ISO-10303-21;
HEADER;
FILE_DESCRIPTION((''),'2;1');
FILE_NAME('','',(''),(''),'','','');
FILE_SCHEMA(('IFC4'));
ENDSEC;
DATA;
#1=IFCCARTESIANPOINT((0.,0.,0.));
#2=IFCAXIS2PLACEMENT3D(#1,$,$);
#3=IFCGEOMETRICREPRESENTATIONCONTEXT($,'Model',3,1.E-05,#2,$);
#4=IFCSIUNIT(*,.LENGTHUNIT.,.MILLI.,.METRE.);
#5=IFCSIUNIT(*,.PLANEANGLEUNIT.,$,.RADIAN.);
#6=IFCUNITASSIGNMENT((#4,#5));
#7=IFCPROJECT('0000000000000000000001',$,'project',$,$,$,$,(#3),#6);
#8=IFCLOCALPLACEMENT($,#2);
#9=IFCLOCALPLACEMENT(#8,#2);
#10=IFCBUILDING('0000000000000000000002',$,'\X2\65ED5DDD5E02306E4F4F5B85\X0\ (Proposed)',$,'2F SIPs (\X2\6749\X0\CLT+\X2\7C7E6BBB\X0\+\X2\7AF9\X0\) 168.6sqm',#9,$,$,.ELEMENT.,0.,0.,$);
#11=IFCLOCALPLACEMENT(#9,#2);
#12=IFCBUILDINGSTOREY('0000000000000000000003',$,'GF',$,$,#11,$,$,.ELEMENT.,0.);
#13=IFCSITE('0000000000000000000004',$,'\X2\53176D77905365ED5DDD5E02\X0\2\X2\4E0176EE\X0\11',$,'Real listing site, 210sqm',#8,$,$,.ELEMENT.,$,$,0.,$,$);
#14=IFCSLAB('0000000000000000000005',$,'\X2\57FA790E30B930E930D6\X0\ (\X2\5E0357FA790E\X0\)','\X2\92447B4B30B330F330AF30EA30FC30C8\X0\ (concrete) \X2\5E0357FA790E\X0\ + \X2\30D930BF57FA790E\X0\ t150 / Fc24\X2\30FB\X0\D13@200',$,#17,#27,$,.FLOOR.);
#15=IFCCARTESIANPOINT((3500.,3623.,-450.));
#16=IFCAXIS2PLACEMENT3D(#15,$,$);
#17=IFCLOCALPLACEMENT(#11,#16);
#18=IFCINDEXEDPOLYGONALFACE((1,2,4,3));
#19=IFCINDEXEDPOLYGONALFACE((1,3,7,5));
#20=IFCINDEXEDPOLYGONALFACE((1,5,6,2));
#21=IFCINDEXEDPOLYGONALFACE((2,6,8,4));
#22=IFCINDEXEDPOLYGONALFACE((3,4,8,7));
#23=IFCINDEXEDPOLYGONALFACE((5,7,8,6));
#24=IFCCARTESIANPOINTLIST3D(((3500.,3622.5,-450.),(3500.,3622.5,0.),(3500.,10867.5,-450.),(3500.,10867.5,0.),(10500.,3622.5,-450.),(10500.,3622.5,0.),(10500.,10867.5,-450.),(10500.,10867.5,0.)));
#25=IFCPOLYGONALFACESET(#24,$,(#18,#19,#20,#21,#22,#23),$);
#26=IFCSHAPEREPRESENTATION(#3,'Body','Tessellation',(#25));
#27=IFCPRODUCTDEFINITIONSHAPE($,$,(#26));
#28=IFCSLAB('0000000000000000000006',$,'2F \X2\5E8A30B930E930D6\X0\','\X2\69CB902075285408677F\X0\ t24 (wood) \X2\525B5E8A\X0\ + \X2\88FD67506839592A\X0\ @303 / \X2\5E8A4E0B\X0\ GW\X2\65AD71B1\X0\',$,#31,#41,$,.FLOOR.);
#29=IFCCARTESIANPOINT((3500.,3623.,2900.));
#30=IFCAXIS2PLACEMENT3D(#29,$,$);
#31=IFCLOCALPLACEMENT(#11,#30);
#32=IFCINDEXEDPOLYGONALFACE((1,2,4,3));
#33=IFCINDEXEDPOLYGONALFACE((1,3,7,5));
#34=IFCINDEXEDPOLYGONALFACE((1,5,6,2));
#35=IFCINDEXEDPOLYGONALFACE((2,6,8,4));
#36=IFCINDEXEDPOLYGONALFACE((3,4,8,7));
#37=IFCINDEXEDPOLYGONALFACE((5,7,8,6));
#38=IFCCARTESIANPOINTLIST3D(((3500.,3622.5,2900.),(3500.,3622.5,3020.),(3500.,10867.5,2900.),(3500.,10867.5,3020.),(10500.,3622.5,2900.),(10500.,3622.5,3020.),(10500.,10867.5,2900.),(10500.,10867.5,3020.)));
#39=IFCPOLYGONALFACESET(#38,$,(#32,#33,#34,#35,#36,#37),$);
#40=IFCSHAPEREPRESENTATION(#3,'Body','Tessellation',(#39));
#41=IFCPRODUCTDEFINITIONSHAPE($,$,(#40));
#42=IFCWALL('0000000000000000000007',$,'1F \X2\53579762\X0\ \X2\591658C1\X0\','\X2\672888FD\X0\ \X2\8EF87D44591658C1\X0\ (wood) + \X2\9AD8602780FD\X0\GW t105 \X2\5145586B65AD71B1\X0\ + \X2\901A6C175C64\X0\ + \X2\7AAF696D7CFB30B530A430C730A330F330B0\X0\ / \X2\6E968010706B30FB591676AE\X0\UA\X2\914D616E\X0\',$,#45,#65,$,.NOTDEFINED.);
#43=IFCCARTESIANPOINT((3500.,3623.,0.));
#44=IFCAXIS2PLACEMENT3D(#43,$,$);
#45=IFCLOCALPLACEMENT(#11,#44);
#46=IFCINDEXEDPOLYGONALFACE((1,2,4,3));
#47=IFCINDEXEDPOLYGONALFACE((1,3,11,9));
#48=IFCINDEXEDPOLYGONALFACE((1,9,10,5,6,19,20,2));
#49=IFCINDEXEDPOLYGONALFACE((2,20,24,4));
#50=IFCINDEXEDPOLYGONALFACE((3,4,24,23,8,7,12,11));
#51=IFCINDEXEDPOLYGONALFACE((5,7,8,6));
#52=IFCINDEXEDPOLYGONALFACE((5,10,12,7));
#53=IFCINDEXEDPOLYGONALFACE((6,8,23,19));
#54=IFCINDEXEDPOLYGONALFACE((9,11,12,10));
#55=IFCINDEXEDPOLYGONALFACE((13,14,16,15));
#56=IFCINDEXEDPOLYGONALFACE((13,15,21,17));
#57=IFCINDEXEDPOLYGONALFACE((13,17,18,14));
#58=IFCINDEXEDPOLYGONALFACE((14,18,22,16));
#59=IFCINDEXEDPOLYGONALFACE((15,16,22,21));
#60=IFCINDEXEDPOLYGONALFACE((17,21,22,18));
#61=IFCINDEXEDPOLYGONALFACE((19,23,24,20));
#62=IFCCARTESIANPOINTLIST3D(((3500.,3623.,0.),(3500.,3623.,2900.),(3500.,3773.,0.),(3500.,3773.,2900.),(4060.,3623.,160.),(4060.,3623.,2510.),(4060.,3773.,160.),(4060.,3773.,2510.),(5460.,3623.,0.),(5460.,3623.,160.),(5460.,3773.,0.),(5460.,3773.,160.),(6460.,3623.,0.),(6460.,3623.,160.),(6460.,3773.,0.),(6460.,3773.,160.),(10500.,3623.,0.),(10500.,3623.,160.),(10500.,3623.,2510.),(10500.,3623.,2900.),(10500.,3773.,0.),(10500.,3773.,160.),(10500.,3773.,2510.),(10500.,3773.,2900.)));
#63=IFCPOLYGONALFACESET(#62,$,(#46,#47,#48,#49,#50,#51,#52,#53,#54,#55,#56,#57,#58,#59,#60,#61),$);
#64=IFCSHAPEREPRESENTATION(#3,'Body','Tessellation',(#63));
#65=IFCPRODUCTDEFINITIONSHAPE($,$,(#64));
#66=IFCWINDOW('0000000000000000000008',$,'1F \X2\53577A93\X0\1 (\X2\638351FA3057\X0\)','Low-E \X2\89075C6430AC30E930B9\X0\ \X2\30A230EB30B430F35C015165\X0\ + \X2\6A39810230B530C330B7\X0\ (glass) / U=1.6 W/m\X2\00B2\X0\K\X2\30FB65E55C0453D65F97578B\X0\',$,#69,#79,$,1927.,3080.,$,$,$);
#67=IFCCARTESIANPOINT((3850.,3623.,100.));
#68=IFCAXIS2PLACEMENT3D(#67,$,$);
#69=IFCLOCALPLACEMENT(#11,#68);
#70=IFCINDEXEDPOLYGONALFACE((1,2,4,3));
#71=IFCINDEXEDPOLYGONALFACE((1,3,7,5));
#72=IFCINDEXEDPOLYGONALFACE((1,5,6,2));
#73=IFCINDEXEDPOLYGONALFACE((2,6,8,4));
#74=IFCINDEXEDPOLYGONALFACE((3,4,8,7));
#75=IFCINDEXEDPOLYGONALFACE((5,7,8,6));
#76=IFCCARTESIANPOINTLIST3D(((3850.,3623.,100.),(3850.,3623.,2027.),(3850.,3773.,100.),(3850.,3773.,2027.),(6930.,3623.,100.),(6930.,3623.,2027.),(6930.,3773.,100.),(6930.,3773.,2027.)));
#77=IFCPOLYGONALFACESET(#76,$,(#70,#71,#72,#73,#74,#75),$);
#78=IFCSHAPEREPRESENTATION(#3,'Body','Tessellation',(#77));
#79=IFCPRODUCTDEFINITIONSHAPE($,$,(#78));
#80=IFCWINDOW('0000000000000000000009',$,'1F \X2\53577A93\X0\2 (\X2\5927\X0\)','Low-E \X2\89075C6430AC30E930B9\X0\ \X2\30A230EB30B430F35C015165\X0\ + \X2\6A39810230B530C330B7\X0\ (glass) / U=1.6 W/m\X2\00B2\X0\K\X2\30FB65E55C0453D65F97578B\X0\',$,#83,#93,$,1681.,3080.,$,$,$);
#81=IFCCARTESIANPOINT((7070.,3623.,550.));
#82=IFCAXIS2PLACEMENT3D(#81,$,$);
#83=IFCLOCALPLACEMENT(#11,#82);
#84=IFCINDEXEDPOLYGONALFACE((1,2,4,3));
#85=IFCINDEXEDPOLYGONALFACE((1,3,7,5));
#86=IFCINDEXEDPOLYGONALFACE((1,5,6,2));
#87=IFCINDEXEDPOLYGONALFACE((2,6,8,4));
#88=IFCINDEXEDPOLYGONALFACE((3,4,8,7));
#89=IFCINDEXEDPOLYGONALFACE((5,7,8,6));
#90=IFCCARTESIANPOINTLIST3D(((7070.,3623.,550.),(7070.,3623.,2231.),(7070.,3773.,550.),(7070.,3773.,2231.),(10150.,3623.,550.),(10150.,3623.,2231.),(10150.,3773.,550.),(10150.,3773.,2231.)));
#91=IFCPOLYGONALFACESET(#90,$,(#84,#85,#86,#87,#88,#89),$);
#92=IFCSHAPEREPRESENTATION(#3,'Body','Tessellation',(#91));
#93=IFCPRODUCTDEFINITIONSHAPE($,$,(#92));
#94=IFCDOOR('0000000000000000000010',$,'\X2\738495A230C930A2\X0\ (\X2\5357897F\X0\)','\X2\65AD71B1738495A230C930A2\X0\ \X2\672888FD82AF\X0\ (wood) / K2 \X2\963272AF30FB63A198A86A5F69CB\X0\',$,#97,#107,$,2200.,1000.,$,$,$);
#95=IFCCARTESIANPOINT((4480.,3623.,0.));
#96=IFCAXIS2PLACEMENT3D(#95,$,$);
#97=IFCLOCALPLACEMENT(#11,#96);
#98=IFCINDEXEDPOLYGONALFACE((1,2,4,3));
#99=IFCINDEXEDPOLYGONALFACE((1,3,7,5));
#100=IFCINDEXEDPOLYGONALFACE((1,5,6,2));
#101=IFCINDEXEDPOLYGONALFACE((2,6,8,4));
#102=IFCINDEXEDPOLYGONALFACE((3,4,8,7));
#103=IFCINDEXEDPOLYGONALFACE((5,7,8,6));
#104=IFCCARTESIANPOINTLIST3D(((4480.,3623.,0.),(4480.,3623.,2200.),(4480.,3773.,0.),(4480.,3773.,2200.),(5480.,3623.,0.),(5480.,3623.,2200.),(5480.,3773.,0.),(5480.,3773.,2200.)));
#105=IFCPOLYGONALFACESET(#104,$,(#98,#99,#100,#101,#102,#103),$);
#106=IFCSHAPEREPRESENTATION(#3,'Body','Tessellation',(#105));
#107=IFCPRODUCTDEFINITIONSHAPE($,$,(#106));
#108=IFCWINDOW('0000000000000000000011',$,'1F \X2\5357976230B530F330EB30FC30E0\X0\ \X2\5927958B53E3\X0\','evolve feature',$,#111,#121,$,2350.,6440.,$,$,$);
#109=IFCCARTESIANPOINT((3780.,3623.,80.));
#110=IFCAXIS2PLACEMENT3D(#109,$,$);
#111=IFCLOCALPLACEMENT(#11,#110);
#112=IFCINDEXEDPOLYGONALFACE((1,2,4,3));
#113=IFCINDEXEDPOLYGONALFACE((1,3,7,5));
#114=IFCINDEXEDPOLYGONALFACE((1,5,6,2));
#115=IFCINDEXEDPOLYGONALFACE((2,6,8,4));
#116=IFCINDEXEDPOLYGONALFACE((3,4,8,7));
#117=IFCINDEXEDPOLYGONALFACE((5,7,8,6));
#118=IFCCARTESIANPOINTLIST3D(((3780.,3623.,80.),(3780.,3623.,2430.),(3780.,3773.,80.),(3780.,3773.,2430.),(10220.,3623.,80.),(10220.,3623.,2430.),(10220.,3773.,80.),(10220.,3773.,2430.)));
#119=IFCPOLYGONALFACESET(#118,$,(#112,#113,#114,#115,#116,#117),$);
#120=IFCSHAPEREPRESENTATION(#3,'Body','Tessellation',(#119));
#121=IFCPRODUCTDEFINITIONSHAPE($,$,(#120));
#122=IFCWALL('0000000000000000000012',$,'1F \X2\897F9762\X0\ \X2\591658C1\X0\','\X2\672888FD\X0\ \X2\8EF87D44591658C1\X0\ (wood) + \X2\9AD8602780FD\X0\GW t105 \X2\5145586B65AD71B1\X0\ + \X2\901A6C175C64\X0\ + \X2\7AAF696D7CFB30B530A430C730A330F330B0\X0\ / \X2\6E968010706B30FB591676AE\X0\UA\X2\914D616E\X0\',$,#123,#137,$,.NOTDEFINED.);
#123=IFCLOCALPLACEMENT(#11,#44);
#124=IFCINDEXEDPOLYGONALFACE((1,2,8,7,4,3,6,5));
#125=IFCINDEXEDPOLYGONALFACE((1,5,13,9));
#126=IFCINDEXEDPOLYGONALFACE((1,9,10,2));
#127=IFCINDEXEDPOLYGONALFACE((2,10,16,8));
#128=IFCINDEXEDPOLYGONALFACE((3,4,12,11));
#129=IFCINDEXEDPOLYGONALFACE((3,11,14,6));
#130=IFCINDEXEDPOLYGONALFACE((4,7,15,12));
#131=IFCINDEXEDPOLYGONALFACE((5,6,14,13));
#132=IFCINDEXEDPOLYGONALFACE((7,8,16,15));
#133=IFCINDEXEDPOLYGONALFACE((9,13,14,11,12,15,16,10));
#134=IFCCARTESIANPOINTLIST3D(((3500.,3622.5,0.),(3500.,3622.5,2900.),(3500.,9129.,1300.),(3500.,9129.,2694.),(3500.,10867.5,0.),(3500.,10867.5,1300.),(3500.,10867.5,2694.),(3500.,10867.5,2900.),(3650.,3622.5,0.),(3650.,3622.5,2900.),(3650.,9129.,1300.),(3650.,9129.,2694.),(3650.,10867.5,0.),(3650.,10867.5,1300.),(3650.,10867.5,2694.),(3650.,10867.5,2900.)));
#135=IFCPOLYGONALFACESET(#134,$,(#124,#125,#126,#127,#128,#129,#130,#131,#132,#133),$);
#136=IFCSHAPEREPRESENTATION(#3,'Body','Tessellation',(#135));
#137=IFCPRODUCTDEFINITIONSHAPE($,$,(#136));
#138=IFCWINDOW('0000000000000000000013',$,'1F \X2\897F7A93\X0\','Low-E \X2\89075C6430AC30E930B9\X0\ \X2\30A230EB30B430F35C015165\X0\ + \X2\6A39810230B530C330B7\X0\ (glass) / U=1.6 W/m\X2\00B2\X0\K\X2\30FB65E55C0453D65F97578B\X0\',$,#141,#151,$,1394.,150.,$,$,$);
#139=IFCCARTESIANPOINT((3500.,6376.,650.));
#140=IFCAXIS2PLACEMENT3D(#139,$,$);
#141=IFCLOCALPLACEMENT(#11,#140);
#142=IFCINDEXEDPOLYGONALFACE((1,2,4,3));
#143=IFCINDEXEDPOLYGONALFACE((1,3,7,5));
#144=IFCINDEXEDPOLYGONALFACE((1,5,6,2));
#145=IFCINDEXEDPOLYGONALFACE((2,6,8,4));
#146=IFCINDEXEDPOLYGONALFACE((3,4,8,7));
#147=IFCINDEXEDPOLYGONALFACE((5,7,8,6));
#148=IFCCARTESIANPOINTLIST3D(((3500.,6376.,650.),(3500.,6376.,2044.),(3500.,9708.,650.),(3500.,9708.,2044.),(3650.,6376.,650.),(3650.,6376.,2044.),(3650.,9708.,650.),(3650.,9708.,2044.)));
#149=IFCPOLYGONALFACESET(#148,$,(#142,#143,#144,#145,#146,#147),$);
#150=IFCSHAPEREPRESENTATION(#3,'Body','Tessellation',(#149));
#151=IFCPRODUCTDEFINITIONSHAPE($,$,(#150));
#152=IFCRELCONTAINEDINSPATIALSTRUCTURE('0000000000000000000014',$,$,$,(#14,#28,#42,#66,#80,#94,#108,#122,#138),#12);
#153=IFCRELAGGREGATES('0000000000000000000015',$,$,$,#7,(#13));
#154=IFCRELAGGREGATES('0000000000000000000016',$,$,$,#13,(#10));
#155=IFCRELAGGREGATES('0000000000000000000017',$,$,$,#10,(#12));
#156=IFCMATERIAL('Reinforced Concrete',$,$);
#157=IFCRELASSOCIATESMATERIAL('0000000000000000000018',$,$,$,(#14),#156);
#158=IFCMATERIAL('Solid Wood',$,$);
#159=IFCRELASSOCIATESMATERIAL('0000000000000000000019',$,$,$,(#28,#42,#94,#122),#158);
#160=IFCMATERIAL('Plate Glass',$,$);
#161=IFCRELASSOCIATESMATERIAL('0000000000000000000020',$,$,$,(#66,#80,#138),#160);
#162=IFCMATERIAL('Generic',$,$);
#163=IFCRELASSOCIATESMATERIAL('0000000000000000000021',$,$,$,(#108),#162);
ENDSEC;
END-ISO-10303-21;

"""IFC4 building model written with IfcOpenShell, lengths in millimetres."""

from ifc_helpers import new_model, si_unit, frame, frame_2d, origin, place, context, project, spatial, rectangle, extrude, material, element, fill, save


model = new_model("IFC4")

# Units and contexts
model_context = context("Model", 3, precision=1e-05, world=origin())
ifc_project = project(units=[si_unit("LENGTHUNIT", "METRE", prefix="MILLI"), si_unit("PLANEANGLEUNIT", "RADIAN")], contexts=[model_context])

# Site, building, storey
site_placement = place(None, origin())
site = spatial("IfcSite", under=ifc_project, at=site_placement, Name="北海道旭川市2丁目11", ObjectType="Real listing site, 210sqm", CompositionType="ELEMENT", RefElevation=0.0)
building_placement = place(site_placement, origin())
building = spatial("IfcBuilding", under=site, at=building_placement, Name="旭川市の住宅 (Proposed)", ObjectType="2F SIPs (杉CLT+籾殻+竹) 168.6sqm", CompositionType="ELEMENT", ElevationOfRefHeight=0.0, ElevationOfTerrain=0.0)
storey_placement = place(building_placement, origin())
storey = spatial("IfcBuildingStorey", under=building, at=storey_placement, Name="GF", CompositionType="ELEMENT", Elevation=0.0)

# Slabs
ifc_material_1 = material(Name="Reinforced Concrete")
slab_1_placement = place(storey_placement, frame((3500.0, 3623.0, -450.0)))
element("IfcSlab", 1, at=slab_1_placement, inside=storey, material=ifc_material_1, Name="基礎スラブ (布基礎)", Description="鉄筋コンクリート (concrete) 布基礎 + ベタ基礎 t150 / Fc24・D13@200", PredefinedType="FLOOR", context=model_context, shape_type="SweptSolid", body=[
    extrude(rectangle(XDim=7000.0, YDim=7245.0, at=frame_2d((3500.0, 3622.0))), frame((3500.0, 3623.0, -450.0)), (0.0, 0.0, 1.0), 450.0),
])
ifc_material_2 = material(Name="Solid Wood")
slab_2_placement = place(storey_placement, frame((3500.0, 3623.0, 2900.0)))
element("IfcSlab", 2, at=slab_2_placement, inside=storey, material=ifc_material_2, Name="2F 床スラブ", Description="構造用合板 t24 (wood) 剛床 + 製材根太 @303 / 床下 GW断熱", PredefinedType="FLOOR", context=model_context, shape_type="SweptSolid", body=[
    extrude(rectangle(XDim=7000.0, YDim=7245.0, at=frame_2d((3500.0, 3622.0))), frame((3500.0, 3623.0, 2900.0)), (0.0, 0.0, 1.0), 120.0),
])
ifc_material_3 = material(Name="Generic")

# Wall, openings, windows, door
wall_1_placement = place(storey_placement, frame((3500.0, 3623.0, 0.0)))
wall_1 = element("IfcWall", 3, at=wall_1_placement, inside=storey, material=ifc_material_2, Name="1F 南面 外壁", Description="木製 軸組外壁 (wood) + 高性能GW t105 充填断熱 + 通気層 + 窯業系サイディング / 準耐火・外皮UA配慮", PredefinedType="NOTDEFINED", context=model_context, shape_type="SweptSolid", body=[
    extrude(rectangle(XDim=7000.0, YDim=150.0, at=frame_2d((3500.0, 75.0))), frame((3500.0, 3623.0, 0.0)), (0.0, 0.0, 1.0), 2900.0),
])
opening_1_placement = place(storey_placement, frame((3850.0, 3623.0, 100.0)))
opening_1 = element("IfcOpeningElement", 4, at=opening_1_placement, cuts=wall_1, PredefinedType="NOTDEFINED", context=model_context, shape_type="SweptSolid", body=[
    extrude(rectangle(XDim=3080.0, YDim=150.0, at=frame_2d((1540.0, 75.0))), frame((3850.0, 3623.0, 100.0)), (0.0, 0.0, 1.0), 1927.0),
])
opening_2_placement = place(storey_placement, frame((7070.0, 3623.0, 550.0)))
opening_2 = element("IfcOpeningElement", 5, at=opening_2_placement, cuts=wall_1, PredefinedType="NOTDEFINED", context=model_context, shape_type="SweptSolid", body=[
    extrude(rectangle(XDim=3080.0, YDim=150.0, at=frame_2d((1540.0, 75.0))), frame((7070.0, 3623.0, 550.0)), (0.0, 0.0, 1.0), 1681.0),
])
opening_3_placement = place(storey_placement, frame((4480.0, 3623.0, 0.0)))
opening_3 = element("IfcOpeningElement", 6, at=opening_3_placement, cuts=wall_1, PredefinedType="NOTDEFINED", context=model_context, shape_type="SweptSolid", body=[
    extrude(rectangle(XDim=1000.0, YDim=150.0, at=frame_2d((500.0, 75.0))), frame((4480.0, 3623.0, 0.0)), (0.0, 0.0, 1.0), 2200.0),
])
opening_4_placement = place(storey_placement, frame((3780.0, 3623.0, 80.0)))
opening_4 = element("IfcOpeningElement", 7, at=opening_4_placement, cuts=wall_1, PredefinedType="NOTDEFINED", context=model_context, shape_type="SweptSolid", body=[
    extrude(rectangle(XDim=6440.0, YDim=150.0, at=frame_2d((3220.0, 75.0))), frame((3780.0, 3623.0, 80.0)), (0.0, 0.0, 1.0), 2350.0),
])
ifc_material_4 = material(Name="Plate Glass")
window_1_placement = place(storey_placement, frame((3850.0, 3623.0, 100.0)))
window_1 = element("IfcWindow", 8, at=window_1_placement, inside=storey, material=ifc_material_4, Name="1F 南窓1 (掃出し)", Description="Low-E 複層ガラス アルゴン封入 + 樹脂サッシ (glass) / U=1.6 W/m²K・日射取得型", OverallHeight=1927.0, OverallWidth=3080.0, context=model_context, shape_type="SweptSolid", body=[
    extrude(rectangle(XDim=3080.0, YDim=150.0, at=frame_2d((1540.0, 75.0))), frame((3850.0, 3623.0, 100.0)), (0.0, 0.0, 1.0), 1927.0),
])
fill(opening_1, window_1)
window_2_placement = place(storey_placement, frame((7070.0, 3623.0, 550.0)))
window_2 = element("IfcWindow", 9, at=window_2_placement, inside=storey, material=ifc_material_4, Name="1F 南窓2 (大)", Description="Low-E 複層ガラス アルゴン封入 + 樹脂サッシ (glass) / U=1.6 W/m²K・日射取得型", OverallHeight=1681.0, OverallWidth=3080.0, context=model_context, shape_type="SweptSolid", body=[
    extrude(rectangle(XDim=3080.0, YDim=150.0, at=frame_2d((1540.0, 75.0))), frame((7070.0, 3623.0, 550.0)), (0.0, 0.0, 1.0), 1681.0),
])
fill(opening_2, window_2)
door_placement = place(storey_placement, frame((4480.0, 3623.0, 0.0)))
door = element("IfcDoor", 10, at=door_placement, inside=storey, material=ifc_material_2, Name="玄関ドア (南西)", Description="断熱玄関ドア 木製芯 (wood) / K2 防犯・採風機構", OverallHeight=2200.0, OverallWidth=1000.0, context=model_context, shape_type="SweptSolid", body=[
    extrude(rectangle(XDim=1000.0, YDim=150.0, at=frame_2d((500.0, 75.0))), frame((4480.0, 3623.0, 0.0)), (0.0, 0.0, 1.0), 2200.0),
])
fill(opening_3, door)
window_3_placement = place(storey_placement, frame((3780.0, 3623.0, 80.0)))
window_3 = element("IfcWindow", 11, at=window_3_placement, inside=storey, material=ifc_material_3, Name="1F 南面サンルーム 大開口", Description="evolve feature", OverallHeight=2350.0, OverallWidth=6440.0, context=model_context, shape_type="SweptSolid", body=[
    extrude(rectangle(XDim=6440.0, YDim=150.0, at=frame_2d((3220.0, 75.0))), frame((3780.0, 3623.0, 80.0)), (0.0, 0.0, 1.0), 2350.0),
])
fill(opening_4, window_3)

# Wall, opening, window
wall_2_placement = place(storey_placement, frame((3500.0, 3623.0, 0.0)))
wall_2 = element("IfcWall", 12, at=wall_2_placement, inside=storey, material=ifc_material_2, Name="1F 西面 外壁", Description="木製 軸組外壁 (wood) + 高性能GW t105 充填断熱 + 通気層 + 窯業系サイディング / 準耐火・外皮UA配慮", PredefinedType="NOTDEFINED", context=model_context, shape_type="SweptSolid", body=[
    extrude(rectangle(XDim=150.0, YDim=7245.0, at=frame_2d((75.0, 3622.0))), frame((3500.0, 3623.0, 0.0)), (0.0, 0.0, 1.0), 2900.0),
])
opening_5_placement = place(storey_placement, frame((3500.0, 6376.0, 650.0)))
opening_5 = element("IfcOpeningElement", 13, at=opening_5_placement, cuts=wall_2, PredefinedType="NOTDEFINED", context=model_context, shape_type="SweptSolid", body=[
    extrude(rectangle(XDim=150.0, YDim=3332.0, at=frame_2d((75.0, 1666.0))), frame((3500.0, 6376.0, 650.0)), (0.0, 0.0, 1.0), 1394.0),
])
window_4_placement = place(storey_placement, frame((3500.0, 6376.0, 650.0)))
window_4 = element("IfcWindow", 14, at=window_4_placement, inside=storey, material=ifc_material_4, Name="1F 西窓", Description="Low-E 複層ガラス アルゴン封入 + 樹脂サッシ (glass) / U=1.6 W/m²K・日射取得型", OverallHeight=1394.0, OverallWidth=150.0, context=model_context, shape_type="SweptSolid", body=[
    extrude(rectangle(XDim=150.0, YDim=3332.0, at=frame_2d((75.0, 1666.0))), frame((3500.0, 6376.0, 650.0)), (0.0, 0.0, 1.0), 1394.0),
])
fill(opening_5, window_4)

save(model, "model.ifc")
